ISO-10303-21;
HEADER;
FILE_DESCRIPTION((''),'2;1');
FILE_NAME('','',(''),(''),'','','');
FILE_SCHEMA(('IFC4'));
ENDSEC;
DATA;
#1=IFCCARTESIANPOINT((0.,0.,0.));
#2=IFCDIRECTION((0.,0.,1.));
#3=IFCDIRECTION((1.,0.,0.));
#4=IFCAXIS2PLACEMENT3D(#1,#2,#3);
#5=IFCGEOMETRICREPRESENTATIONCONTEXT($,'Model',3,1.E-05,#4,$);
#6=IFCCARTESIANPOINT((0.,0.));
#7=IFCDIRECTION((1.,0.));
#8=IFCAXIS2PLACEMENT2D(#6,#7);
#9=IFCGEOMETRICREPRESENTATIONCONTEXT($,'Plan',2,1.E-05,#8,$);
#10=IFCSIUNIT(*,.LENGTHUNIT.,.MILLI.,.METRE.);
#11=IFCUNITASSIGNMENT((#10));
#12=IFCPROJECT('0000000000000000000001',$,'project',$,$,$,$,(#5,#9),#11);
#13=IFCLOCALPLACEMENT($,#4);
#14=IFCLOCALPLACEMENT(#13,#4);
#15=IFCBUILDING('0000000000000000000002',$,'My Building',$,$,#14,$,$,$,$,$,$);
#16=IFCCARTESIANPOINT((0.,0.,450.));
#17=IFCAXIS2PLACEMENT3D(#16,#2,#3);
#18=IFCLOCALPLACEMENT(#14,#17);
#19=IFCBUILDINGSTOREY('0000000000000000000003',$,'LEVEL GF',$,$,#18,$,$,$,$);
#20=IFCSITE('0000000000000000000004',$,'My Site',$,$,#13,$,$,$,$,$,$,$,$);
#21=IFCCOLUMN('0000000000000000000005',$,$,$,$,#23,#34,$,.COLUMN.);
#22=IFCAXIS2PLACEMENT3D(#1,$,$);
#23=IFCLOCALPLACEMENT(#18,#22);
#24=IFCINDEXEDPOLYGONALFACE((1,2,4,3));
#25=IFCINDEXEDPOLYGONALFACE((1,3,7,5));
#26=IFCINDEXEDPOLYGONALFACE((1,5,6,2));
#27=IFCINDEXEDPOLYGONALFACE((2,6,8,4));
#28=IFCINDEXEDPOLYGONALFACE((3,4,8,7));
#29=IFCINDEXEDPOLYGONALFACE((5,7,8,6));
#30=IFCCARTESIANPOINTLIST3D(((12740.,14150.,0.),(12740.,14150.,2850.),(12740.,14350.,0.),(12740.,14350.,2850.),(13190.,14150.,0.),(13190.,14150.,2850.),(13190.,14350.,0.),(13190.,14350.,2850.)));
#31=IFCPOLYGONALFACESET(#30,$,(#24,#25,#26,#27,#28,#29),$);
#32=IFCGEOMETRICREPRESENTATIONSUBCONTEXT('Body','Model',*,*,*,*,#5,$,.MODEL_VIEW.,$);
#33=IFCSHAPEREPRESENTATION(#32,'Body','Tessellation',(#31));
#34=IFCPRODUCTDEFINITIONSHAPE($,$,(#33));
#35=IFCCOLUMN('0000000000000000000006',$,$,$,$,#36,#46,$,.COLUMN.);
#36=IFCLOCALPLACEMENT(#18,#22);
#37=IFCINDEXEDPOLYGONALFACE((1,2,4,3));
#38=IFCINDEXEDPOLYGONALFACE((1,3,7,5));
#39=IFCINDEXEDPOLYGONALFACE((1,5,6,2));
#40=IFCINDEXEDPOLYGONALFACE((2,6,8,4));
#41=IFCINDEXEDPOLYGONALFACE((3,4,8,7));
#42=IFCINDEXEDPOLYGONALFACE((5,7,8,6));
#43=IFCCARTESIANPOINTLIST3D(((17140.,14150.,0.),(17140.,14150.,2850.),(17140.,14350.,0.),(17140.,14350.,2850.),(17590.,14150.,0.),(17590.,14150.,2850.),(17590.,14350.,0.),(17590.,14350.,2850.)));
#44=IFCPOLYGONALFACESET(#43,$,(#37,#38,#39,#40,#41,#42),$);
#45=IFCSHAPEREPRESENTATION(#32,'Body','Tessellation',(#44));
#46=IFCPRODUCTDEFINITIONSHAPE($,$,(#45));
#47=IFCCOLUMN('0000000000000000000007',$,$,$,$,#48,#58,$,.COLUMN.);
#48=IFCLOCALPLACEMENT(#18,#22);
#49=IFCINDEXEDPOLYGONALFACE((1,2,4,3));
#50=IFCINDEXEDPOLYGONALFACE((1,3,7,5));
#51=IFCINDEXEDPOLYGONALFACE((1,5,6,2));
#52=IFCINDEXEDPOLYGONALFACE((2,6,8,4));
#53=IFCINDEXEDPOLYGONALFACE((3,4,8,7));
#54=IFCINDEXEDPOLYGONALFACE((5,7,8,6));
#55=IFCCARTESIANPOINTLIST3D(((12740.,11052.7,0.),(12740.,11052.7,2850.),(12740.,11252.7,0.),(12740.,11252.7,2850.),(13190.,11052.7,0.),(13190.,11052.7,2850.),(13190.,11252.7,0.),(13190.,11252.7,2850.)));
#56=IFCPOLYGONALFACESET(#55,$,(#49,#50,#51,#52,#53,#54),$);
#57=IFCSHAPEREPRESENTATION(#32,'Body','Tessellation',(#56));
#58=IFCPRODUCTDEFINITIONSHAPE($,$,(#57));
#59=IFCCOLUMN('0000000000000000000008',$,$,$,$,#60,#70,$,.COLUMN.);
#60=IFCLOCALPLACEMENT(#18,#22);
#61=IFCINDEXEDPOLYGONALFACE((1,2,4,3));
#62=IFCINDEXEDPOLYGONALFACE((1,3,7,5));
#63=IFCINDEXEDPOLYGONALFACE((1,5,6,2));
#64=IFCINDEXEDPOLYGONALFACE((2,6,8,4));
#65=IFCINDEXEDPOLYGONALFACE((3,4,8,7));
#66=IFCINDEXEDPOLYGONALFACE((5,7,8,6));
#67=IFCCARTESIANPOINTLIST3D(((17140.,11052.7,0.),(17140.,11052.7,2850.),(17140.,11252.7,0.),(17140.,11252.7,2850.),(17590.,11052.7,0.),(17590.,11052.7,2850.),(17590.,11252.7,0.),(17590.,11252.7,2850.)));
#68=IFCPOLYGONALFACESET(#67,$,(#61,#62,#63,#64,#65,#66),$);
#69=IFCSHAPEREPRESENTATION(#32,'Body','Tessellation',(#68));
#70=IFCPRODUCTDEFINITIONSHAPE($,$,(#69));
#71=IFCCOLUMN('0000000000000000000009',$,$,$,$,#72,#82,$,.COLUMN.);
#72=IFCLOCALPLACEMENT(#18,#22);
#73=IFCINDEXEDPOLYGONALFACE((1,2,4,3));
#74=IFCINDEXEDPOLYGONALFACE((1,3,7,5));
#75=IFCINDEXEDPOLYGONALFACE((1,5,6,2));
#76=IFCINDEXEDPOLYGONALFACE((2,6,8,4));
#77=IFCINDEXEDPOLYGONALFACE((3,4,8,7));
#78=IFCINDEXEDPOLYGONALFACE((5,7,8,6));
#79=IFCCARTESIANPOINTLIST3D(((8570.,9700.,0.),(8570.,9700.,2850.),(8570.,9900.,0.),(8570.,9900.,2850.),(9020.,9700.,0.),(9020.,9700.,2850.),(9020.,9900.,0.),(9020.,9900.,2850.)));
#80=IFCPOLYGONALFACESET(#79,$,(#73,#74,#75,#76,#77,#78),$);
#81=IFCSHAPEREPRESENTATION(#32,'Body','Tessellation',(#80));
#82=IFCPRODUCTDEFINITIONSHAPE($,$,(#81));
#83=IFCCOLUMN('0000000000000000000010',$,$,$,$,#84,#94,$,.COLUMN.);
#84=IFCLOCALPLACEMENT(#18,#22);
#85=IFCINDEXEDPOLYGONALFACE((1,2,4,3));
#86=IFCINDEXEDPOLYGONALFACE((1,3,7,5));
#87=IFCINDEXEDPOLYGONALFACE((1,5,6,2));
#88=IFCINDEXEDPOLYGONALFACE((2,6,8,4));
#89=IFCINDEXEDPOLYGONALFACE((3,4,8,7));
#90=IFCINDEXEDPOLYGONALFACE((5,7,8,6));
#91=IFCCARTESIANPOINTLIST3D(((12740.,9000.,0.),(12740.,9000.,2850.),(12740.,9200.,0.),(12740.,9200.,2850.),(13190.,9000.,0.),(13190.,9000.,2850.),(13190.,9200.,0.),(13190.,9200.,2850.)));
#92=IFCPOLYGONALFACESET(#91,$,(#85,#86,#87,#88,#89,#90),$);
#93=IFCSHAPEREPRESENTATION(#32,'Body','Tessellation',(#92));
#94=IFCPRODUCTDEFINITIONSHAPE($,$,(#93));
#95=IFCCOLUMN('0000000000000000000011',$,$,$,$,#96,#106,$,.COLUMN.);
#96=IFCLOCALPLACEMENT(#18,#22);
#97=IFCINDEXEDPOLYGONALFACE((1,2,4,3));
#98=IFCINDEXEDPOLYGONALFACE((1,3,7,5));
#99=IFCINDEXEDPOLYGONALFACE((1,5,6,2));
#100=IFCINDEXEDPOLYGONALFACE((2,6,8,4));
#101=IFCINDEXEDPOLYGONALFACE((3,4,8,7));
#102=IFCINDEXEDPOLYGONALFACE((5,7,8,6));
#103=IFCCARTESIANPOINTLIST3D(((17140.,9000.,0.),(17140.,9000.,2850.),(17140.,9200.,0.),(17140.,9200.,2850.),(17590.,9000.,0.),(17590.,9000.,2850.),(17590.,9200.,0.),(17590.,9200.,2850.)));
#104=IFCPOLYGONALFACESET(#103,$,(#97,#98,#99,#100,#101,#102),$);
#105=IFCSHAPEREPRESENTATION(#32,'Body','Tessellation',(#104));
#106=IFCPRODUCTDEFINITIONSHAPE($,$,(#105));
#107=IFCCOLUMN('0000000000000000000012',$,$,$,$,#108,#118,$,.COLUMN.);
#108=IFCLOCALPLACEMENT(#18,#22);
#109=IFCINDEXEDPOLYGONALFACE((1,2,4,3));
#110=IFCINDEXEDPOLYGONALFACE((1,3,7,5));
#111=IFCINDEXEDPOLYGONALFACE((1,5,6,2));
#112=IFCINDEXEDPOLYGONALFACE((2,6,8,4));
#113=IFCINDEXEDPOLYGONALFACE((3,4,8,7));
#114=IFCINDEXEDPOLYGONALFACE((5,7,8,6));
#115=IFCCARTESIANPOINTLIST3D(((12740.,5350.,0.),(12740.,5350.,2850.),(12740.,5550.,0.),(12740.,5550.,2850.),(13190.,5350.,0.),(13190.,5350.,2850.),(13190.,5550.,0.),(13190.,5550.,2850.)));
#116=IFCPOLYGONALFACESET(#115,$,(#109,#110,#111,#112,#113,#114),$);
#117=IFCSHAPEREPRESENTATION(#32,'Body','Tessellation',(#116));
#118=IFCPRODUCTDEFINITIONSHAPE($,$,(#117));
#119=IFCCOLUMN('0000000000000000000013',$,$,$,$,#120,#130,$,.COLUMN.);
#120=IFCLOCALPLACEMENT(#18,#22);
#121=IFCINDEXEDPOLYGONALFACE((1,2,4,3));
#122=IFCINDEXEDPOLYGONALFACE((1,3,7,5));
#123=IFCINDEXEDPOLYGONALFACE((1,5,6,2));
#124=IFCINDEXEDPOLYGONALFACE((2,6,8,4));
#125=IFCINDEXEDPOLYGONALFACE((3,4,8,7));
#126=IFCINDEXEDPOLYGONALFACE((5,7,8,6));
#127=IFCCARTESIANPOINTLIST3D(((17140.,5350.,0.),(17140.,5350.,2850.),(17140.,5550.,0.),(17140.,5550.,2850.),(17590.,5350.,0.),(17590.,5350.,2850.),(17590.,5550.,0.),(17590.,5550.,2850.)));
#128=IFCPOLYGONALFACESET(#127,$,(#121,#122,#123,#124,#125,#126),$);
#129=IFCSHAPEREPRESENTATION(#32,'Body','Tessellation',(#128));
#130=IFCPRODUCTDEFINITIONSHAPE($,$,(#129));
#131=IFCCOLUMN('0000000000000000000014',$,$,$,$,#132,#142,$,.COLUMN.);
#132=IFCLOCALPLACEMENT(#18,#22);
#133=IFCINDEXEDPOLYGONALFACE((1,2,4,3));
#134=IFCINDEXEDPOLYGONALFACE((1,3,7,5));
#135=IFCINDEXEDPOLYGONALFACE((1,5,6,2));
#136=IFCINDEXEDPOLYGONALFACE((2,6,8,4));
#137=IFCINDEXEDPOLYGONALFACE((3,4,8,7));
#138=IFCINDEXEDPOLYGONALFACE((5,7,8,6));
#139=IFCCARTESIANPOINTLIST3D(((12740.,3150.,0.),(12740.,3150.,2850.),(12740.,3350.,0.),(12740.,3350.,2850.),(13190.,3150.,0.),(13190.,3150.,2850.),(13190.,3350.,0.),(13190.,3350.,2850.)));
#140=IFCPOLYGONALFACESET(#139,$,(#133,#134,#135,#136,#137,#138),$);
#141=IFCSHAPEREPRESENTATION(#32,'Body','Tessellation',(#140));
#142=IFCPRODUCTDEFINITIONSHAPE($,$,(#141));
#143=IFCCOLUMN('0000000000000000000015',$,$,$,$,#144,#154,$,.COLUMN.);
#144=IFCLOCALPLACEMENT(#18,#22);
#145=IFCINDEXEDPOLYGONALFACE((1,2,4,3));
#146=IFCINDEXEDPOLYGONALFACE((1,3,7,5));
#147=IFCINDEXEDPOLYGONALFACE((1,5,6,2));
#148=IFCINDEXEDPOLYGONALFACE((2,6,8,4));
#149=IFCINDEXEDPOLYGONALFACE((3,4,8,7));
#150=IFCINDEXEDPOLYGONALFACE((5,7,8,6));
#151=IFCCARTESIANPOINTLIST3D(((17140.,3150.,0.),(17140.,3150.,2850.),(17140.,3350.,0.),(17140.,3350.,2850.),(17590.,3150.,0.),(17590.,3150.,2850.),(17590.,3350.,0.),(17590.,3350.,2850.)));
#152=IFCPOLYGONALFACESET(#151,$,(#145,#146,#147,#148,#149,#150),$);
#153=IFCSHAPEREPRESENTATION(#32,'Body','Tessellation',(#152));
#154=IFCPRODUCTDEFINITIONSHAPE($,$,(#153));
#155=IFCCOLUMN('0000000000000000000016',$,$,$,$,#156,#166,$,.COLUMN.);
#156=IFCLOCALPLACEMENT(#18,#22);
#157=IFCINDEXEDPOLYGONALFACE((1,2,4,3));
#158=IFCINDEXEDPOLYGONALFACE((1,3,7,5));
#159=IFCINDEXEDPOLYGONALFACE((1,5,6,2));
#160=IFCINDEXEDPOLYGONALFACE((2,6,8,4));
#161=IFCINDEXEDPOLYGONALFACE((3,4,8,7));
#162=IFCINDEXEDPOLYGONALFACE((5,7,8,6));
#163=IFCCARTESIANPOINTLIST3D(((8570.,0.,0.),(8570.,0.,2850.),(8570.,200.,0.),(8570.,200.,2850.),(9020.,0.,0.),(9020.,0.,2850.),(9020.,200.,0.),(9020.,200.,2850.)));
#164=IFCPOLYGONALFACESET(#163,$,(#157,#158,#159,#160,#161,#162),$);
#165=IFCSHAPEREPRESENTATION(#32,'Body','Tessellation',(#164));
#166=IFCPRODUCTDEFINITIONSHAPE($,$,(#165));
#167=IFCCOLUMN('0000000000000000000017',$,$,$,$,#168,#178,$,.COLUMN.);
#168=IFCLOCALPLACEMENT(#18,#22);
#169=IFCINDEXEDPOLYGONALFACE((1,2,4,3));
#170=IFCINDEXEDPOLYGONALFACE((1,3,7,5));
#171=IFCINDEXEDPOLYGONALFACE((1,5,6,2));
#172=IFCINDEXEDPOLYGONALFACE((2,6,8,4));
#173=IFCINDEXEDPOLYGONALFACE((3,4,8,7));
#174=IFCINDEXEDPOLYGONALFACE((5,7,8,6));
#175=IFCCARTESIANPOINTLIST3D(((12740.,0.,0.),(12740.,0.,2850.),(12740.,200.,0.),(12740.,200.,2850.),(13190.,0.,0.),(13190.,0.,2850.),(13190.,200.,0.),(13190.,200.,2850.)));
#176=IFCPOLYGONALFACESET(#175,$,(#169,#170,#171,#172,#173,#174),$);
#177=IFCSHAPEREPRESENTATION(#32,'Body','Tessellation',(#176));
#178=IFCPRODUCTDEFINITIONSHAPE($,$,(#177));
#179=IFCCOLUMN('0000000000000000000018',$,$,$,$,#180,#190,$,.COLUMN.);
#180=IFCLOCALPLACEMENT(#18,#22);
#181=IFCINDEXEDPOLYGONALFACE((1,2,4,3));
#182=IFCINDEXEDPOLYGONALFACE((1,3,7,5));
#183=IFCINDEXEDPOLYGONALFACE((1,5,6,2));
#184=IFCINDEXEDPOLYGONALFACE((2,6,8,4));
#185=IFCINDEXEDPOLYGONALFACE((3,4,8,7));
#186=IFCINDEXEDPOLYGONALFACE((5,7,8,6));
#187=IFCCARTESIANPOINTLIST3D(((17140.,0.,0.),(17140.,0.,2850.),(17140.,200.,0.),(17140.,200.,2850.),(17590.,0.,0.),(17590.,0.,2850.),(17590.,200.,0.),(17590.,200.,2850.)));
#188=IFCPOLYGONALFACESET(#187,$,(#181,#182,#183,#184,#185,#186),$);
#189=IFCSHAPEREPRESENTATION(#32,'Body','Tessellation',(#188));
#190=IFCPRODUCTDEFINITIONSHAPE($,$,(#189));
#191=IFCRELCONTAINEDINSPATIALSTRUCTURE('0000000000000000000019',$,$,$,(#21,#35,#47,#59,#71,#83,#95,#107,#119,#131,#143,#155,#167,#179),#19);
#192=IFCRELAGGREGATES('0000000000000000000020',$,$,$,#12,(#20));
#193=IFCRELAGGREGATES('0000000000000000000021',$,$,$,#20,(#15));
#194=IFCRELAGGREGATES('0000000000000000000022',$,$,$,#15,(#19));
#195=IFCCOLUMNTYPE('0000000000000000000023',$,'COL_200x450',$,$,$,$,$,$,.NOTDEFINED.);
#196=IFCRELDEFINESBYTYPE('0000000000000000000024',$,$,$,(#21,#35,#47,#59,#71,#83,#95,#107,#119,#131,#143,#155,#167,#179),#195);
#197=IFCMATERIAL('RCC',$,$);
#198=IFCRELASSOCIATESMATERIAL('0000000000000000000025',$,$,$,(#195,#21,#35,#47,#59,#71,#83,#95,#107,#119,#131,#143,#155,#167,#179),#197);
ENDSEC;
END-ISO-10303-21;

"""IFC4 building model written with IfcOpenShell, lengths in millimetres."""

from ifc_helpers import new_model, si_unit, frame, origin_with_axes, origin_2d_with_axis, place, context, subcontext, project, spatial, rectangle, extrude, material, material_profile, profile_set, profile_usage, type_object, element, save


model = new_model("IFC4")

# Units and contexts
model_context = context("Model", 3, precision=1e-05, world=origin_with_axes())
plan_context = context("Plan", 2, precision=1e-05, world=origin_2d_with_axis())
body_context = subcontext(model_context, "Body", "Model", "MODEL_VIEW")
ifc_project = project(units=[si_unit("LENGTHUNIT", "METRE", prefix="MILLI")], contexts=[model_context, plan_context])

# Site, building, storey
site_placement = place(None, origin_with_axes())
site = spatial("IfcSite", under=ifc_project, at=site_placement, Name="My Site")
building_placement = place(site_placement, origin_with_axes())
building = spatial("IfcBuilding", under=site, at=building_placement, Name="My Building")
storey_placement = place(building_placement, frame((0.0, 0.0, 450.0), z_axis=(0.0, 0.0, 1.0), x_axis=(1.0, 0.0, 0.0)))
storey = spatial("IfcBuildingStorey", under=building, at=storey_placement, Name="LEVEL GF")

# Columns
ifc_material_1 = material(Name="RCC")
ifc_material_profile = material_profile(ifc_material_1, rectangle(XDim=200.0, YDim=450.0))
ifc_profile_set = profile_set([ifc_material_profile], Name="COL_200x450")
ifc_profile_usage_1 = profile_usage(ifc_profile_set)
column_type = type_object("IfcColumnType", Name="COL_200x450", PredefinedType="NOTDEFINED", material=ifc_profile_set)
column_1_placement = place(storey_placement, frame((12965.0, 14250.0, 0.0), z_axis=(0.0, 0.0, 1.0), x_axis=(0.0, -1.0, 0.0)))
element("IfcColumn", 1, at=column_1_placement, inside=storey, type_object=column_type, material=ifc_profile_usage_1, PredefinedType="COLUMN", context=body_context, shape_type="SweptSolid", body=[
    extrude(rectangle(XDim=200.0, YDim=450.0), origin_with_axes(), (0.0, 0.0, 1.0), 2850.0),
])
ifc_profile_usage_2 = profile_usage(ifc_profile_set)
column_2_placement = place(storey_placement, frame((17365.0, 14250.0, 0.0), z_axis=(0.0, 0.0, 1.0), x_axis=(0.0, -1.0, 0.0)))
element("IfcColumn", 2, at=column_2_placement, inside=storey, type_object=column_type, material=ifc_profile_usage_2, PredefinedType="COLUMN", context=body_context, shape_type="SweptSolid", body=[
    extrude(rectangle(XDim=200.0, YDim=450.0), origin_with_axes(), (0.0, 0.0, 1.0), 2850.0),
])
ifc_profile_usage_3 = profile_usage(ifc_profile_set)
column_3_placement = place(storey_placement, frame((12965.0, 11152.7, 0.0), z_axis=(0.0, 0.0, 1.0), x_axis=(0.0, -1.0, 0.0)))
element("IfcColumn", 3, at=column_3_placement, inside=storey, type_object=column_type, material=ifc_profile_usage_3, PredefinedType="COLUMN", context=body_context, shape_type="SweptSolid", body=[
    extrude(rectangle(XDim=200.0, YDim=450.0), origin_with_axes(), (0.0, 0.0, 1.0), 2850.0),
])
ifc_profile_usage_4 = profile_usage(ifc_profile_set)
column_4_placement = place(storey_placement, frame((17365.0, 11152.7, 0.0), z_axis=(0.0, 0.0, 1.0), x_axis=(0.0, -1.0, 0.0)))
element("IfcColumn", 4, at=column_4_placement, inside=storey, type_object=column_type, material=ifc_profile_usage_4, PredefinedType="COLUMN", context=body_context, shape_type="SweptSolid", body=[
    extrude(rectangle(XDim=200.0, YDim=450.0), origin_with_axes(), (0.0, 0.0, 1.0), 2850.0),
])
ifc_profile_usage_5 = profile_usage(ifc_profile_set)
column_5_placement = place(storey_placement, frame((8795.0, 9800.0, 0.0), z_axis=(0.0, 0.0, 1.0), x_axis=(0.0, -1.0, 0.0)))
element("IfcColumn", 5, at=column_5_placement, inside=storey, type_object=column_type, material=ifc_profile_usage_5, PredefinedType="COLUMN", context=body_context, shape_type="SweptSolid", body=[
    extrude(rectangle(XDim=200.0, YDim=450.0), origin_with_axes(), (0.0, 0.0, 1.0), 2850.0),
])
ifc_profile_usage_6 = profile_usage(ifc_profile_set)
column_6_placement = place(storey_placement, frame((12965.0, 9100.0, 0.0), z_axis=(0.0, 0.0, 1.0), x_axis=(0.0, -1.0, 0.0)))
element("IfcColumn", 6, at=column_6_placement, inside=storey, type_object=column_type, material=ifc_profile_usage_6, PredefinedType="COLUMN", context=body_context, shape_type="SweptSolid", body=[
    extrude(rectangle(XDim=200.0, YDim=450.0), origin_with_axes(), (0.0, 0.0, 1.0), 2850.0),
])
ifc_profile_usage_7 = profile_usage(ifc_profile_set)
column_7_placement = place(storey_placement, frame((17365.0, 9100.0, 0.0), z_axis=(0.0, 0.0, 1.0), x_axis=(0.0, -1.0, 0.0)))
element("IfcColumn", 7, at=column_7_placement, inside=storey, type_object=column_type, material=ifc_profile_usage_7, PredefinedType="COLUMN", context=body_context, shape_type="SweptSolid", body=[
    extrude(rectangle(XDim=200.0, YDim=450.0), origin_with_axes(), (0.0, 0.0, 1.0), 2850.0),
])
ifc_profile_usage_8 = profile_usage(ifc_profile_set)
column_8_placement = place(storey_placement, frame((12965.0, 5450.0, 0.0), z_axis=(0.0, 0.0, 1.0), x_axis=(0.0, -1.0, 0.0)))
element("IfcColumn", 8, at=column_8_placement, inside=storey, type_object=column_type, material=ifc_profile_usage_8, PredefinedType="COLUMN", context=body_context, shape_type="SweptSolid", body=[
    extrude(rectangle(XDim=200.0, YDim=450.0), origin_with_axes(), (0.0, 0.0, 1.0), 2850.0),
])
ifc_profile_usage_9 = profile_usage(ifc_profile_set)
column_9_placement = place(storey_placement, frame((17365.0, 5450.0, 0.0), z_axis=(0.0, 0.0, 1.0), x_axis=(0.0, -1.0, 0.0)))
element("IfcColumn", 9, at=column_9_placement, inside=storey, type_object=column_type, material=ifc_profile_usage_9, PredefinedType="COLUMN", context=body_context, shape_type="SweptSolid", body=[
    extrude(rectangle(XDim=200.0, YDim=450.0), origin_with_axes(), (0.0, 0.0, 1.0), 2850.0),
])
ifc_profile_usage_10 = profile_usage(ifc_profile_set)
column_10_placement = place(storey_placement, frame((12965.0, 3250.0, 0.0), z_axis=(0.0, 0.0, 1.0), x_axis=(0.0, -1.0, 0.0)))
element("IfcColumn", 10, at=column_10_placement, inside=storey, type_object=column_type, material=ifc_profile_usage_10, PredefinedType="COLUMN", context=body_context, shape_type="SweptSolid", body=[
    extrude(rectangle(XDim=200.0, YDim=450.0), origin_with_axes(), (0.0, 0.0, 1.0), 2850.0),
])
ifc_profile_usage_11 = profile_usage(ifc_profile_set)
column_11_placement = place(storey_placement, frame((17365.0, 3250.0, 0.0), z_axis=(0.0, 0.0, 1.0), x_axis=(0.0, -1.0, 0.0)))
element("IfcColumn", 11, at=column_11_placement, inside=storey, type_object=column_type, material=ifc_profile_usage_11, PredefinedType="COLUMN", context=body_context, shape_type="SweptSolid", body=[
    extrude(rectangle(XDim=200.0, YDim=450.0), origin_with_axes(), (0.0, 0.0, 1.0), 2850.0),
])
ifc_profile_usage_12 = profile_usage(ifc_profile_set)
column_12_placement = place(storey_placement, frame((8795.0, 100.0, 0.0), z_axis=(0.0, 0.0, 1.0), x_axis=(0.0, -1.0, 0.0)))
element("IfcColumn", 12, at=column_12_placement, inside=storey, type_object=column_type, material=ifc_profile_usage_12, PredefinedType="COLUMN", context=body_context, shape_type="SweptSolid", body=[
    extrude(rectangle(XDim=200.0, YDim=450.0), origin_with_axes(), (0.0, 0.0, 1.0), 2850.0),
])
ifc_profile_usage_13 = profile_usage(ifc_profile_set)
column_13_placement = place(storey_placement, frame((12965.0, 100.0, 0.0), z_axis=(0.0, 0.0, 1.0), x_axis=(0.0, -1.0, 0.0)))
element("IfcColumn", 13, at=column_13_placement, inside=storey, type_object=column_type, material=ifc_profile_usage_13, PredefinedType="COLUMN", context=body_context, shape_type="SweptSolid", body=[
    extrude(rectangle(XDim=200.0, YDim=450.0), origin_with_axes(), (0.0, 0.0, 1.0), 2850.0),
])
ifc_profile_usage_14 = profile_usage(ifc_profile_set)
column_14_placement = place(storey_placement, frame((17365.0, 100.0, 0.0), z_axis=(0.0, 0.0, 1.0), x_axis=(0.0, -1.0, 0.0)))
element("IfcColumn", 14, at=column_14_placement, inside=storey, type_object=column_type, material=ifc_profile_usage_14, PredefinedType="COLUMN", context=body_context, shape_type="SweptSolid", body=[
    extrude(rectangle(XDim=200.0, YDim=450.0), origin_with_axes(), (0.0, 0.0, 1.0), 2850.0),
])

save(model, "model.ifc")
